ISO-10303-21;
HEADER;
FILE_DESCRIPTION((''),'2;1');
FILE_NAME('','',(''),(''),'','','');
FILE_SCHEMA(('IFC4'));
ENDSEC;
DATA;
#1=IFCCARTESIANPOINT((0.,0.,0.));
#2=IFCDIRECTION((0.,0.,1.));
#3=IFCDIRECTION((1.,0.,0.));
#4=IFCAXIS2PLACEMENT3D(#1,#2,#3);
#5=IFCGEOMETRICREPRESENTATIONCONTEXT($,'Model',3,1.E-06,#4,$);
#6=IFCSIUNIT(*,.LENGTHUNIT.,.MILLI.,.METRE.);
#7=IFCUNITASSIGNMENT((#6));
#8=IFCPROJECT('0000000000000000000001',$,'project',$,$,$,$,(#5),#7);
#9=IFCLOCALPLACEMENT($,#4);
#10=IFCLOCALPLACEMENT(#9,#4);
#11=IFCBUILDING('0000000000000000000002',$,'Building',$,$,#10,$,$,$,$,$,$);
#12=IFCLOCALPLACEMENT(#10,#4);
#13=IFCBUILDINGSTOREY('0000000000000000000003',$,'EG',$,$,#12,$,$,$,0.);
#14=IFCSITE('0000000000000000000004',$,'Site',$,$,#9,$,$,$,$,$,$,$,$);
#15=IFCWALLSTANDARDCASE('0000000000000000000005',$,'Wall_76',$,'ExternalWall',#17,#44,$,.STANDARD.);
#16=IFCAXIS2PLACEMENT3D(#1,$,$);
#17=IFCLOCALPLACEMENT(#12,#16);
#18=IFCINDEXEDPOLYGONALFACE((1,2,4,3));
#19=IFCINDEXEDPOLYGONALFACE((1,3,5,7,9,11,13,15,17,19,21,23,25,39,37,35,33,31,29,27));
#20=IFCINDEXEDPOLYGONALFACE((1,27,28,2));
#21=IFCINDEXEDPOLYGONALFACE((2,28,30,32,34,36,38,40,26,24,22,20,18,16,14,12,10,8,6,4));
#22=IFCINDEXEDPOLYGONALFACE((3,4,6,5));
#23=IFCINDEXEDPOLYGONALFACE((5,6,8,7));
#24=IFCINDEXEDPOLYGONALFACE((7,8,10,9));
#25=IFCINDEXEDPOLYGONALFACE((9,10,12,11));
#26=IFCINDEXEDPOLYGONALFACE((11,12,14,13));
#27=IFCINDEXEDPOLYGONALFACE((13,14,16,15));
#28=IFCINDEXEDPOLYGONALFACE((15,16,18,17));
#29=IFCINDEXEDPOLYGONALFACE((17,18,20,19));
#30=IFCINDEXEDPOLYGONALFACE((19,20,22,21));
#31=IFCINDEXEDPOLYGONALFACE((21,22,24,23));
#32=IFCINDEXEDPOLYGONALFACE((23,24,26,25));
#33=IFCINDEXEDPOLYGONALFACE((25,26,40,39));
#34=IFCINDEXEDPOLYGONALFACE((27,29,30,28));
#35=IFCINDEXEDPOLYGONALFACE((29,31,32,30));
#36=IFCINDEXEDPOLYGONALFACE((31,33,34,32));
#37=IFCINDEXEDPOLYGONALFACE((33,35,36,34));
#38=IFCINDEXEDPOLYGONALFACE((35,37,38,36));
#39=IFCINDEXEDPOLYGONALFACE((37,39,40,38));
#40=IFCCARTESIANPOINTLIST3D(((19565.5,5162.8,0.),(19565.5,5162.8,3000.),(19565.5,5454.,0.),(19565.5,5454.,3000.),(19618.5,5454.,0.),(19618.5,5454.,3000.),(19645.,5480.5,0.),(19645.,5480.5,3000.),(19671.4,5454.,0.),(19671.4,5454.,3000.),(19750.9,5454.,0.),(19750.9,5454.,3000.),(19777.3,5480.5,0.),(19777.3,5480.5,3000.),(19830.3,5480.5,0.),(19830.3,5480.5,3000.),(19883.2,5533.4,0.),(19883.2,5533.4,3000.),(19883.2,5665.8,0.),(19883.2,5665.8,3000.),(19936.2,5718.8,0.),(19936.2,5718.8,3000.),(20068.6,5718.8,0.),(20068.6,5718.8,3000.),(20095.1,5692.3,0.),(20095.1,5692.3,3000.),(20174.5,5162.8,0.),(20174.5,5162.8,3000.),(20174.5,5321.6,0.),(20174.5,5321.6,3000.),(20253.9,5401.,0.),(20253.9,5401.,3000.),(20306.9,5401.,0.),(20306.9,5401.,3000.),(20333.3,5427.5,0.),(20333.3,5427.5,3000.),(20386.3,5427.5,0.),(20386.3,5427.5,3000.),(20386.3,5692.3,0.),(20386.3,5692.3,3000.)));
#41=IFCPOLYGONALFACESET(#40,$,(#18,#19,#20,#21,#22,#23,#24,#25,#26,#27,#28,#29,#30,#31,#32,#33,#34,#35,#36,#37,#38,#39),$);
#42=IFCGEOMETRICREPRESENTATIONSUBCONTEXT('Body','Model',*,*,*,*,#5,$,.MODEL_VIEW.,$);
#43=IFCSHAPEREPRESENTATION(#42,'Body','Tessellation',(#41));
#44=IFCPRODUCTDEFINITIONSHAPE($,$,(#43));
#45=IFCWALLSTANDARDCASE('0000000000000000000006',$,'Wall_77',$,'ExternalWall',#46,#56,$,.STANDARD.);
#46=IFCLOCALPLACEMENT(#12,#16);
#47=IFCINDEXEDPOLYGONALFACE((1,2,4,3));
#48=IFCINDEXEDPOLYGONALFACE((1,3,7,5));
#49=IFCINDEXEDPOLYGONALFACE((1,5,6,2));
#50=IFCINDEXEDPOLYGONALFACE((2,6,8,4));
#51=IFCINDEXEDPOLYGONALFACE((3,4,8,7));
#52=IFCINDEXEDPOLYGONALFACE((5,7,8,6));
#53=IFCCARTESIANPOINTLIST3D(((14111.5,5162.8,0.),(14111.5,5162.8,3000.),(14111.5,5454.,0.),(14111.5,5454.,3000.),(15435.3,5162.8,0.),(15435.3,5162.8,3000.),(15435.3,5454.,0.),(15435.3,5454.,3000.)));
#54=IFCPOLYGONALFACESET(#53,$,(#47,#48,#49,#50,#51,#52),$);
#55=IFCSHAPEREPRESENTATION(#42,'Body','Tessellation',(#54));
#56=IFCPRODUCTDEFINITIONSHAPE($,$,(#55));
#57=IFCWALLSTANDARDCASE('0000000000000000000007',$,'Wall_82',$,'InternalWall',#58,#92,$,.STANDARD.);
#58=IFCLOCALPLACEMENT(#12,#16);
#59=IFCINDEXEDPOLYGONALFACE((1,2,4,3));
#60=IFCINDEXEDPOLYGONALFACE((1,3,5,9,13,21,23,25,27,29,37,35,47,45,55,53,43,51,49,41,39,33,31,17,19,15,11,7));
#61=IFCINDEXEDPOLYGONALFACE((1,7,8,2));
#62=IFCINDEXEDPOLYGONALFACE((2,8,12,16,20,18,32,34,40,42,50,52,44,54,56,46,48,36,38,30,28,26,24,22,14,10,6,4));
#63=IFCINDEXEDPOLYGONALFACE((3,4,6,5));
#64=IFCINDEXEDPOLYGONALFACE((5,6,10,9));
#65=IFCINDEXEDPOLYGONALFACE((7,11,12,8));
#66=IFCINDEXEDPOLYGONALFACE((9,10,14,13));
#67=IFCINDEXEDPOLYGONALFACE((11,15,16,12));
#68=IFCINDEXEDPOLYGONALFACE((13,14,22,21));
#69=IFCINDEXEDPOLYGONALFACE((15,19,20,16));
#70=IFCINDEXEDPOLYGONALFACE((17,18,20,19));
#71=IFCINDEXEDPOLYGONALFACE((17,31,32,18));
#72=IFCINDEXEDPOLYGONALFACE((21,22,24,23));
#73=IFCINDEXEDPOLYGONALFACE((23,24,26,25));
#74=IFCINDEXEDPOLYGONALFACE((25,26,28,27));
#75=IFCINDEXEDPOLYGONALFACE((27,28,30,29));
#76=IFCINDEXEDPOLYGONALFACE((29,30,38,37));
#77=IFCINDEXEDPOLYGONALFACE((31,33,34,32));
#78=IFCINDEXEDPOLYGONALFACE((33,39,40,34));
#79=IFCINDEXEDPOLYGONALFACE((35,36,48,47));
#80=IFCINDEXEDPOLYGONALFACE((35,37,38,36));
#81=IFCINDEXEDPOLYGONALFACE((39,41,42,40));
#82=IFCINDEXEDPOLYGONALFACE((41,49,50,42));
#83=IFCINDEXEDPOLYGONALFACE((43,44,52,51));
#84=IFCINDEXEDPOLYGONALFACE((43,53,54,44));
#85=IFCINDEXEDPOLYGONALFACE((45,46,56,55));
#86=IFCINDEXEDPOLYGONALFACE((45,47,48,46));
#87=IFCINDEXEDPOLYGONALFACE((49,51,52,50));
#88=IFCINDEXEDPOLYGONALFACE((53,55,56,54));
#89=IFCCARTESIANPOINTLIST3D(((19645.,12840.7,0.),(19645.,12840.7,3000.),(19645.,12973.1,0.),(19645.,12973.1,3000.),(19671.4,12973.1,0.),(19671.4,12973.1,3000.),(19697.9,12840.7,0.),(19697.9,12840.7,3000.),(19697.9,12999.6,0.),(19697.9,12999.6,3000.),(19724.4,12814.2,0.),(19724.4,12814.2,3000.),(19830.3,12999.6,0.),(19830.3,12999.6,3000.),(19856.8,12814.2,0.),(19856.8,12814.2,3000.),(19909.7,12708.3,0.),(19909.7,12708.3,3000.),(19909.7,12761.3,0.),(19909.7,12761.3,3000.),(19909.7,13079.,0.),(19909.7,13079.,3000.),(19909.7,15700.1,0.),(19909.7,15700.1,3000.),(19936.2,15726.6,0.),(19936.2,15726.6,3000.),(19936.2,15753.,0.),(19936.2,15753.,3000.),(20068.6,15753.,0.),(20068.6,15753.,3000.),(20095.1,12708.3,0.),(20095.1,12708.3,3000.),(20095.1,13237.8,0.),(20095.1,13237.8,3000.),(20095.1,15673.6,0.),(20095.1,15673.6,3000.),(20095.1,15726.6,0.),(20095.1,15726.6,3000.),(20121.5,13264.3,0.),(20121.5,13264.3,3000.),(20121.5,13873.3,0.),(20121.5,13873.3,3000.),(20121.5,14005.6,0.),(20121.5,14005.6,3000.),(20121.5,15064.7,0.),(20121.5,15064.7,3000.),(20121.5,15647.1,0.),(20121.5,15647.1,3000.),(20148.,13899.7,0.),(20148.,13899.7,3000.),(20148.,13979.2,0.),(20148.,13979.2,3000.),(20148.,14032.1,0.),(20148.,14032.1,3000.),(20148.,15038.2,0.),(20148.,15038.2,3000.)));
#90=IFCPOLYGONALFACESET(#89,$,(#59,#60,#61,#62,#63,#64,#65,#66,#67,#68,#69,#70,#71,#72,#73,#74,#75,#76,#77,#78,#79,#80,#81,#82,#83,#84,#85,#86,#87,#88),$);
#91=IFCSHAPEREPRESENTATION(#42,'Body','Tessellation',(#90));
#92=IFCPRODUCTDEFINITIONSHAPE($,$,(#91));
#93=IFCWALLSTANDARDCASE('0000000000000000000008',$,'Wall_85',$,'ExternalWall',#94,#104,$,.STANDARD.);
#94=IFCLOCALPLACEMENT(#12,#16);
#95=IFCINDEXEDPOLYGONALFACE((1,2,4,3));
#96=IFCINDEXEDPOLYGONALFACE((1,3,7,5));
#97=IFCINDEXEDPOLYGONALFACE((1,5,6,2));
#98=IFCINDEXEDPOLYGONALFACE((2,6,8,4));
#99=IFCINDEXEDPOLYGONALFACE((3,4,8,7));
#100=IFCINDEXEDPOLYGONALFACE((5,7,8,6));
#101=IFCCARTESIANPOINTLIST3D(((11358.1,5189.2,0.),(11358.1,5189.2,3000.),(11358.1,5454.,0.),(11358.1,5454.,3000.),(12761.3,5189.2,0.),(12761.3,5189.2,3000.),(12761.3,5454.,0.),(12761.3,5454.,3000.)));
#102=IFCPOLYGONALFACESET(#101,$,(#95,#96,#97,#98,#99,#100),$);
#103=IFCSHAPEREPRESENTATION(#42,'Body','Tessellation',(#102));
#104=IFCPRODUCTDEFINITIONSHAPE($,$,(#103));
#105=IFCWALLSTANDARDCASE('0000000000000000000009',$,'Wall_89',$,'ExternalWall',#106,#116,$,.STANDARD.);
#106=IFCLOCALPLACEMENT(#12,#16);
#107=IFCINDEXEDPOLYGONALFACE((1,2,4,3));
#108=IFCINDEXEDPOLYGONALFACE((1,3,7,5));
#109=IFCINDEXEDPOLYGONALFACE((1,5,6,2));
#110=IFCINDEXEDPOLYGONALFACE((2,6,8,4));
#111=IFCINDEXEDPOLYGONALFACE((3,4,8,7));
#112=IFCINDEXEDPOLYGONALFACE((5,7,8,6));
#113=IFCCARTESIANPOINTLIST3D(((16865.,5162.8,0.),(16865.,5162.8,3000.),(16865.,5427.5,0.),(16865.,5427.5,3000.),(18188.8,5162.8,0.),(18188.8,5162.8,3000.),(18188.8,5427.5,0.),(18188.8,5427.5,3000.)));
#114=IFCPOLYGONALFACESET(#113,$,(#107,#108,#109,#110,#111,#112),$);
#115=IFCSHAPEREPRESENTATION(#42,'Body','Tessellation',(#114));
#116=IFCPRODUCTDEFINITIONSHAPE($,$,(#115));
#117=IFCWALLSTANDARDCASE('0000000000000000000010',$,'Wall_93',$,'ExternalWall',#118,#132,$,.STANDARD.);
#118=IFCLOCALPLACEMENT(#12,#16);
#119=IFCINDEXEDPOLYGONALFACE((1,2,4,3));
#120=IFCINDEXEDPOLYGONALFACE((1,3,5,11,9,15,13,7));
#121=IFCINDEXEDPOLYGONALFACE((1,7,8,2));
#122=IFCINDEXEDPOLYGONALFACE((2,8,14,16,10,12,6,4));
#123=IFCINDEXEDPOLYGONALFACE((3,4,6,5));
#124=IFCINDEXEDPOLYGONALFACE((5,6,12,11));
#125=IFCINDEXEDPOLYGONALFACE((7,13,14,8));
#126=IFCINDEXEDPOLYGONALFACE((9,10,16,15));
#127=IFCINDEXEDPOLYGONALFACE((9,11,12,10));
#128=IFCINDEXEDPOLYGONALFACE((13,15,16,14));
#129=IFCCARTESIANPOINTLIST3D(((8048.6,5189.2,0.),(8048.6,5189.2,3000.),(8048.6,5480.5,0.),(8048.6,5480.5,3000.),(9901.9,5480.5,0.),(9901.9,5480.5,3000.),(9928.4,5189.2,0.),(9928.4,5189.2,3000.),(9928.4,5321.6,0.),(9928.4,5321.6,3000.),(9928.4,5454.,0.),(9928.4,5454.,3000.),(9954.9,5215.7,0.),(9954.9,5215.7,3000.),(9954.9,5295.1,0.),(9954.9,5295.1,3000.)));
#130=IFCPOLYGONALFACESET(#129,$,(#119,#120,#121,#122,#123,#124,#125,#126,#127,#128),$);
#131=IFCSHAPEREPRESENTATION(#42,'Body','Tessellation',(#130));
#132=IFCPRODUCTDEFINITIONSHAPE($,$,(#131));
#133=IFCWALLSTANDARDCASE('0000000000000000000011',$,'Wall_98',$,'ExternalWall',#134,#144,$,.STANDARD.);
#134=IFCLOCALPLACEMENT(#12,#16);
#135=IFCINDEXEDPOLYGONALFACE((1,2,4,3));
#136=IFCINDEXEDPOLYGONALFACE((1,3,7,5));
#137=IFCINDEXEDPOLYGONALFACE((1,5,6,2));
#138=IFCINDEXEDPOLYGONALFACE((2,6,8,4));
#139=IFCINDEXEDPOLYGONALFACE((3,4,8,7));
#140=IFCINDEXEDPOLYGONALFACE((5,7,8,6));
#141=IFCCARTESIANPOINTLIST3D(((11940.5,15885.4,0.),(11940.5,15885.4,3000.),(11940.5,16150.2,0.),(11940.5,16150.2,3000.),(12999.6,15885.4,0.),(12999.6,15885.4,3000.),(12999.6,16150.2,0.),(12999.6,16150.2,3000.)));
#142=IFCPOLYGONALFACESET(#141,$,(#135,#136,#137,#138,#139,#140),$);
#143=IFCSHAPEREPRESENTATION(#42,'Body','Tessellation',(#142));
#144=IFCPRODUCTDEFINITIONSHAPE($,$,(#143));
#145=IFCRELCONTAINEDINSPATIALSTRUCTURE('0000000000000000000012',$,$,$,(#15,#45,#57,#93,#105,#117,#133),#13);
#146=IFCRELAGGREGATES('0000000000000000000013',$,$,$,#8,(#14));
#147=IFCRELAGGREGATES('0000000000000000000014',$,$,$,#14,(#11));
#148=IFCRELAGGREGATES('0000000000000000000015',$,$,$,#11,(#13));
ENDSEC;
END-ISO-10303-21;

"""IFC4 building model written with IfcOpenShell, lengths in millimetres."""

from ifc_helpers import new_model, si_unit, frame, origin_with_axes, place, context, subcontext, project, spatial, polyline, outline, extrude, element, save


model = new_model("IFC4")

# Units and contexts
model_context = context("Model", 3, precision=1e-06, world=origin_with_axes())
body_context = subcontext(model_context, "Body", "Model", "MODEL_VIEW")
ifc_project = project(units=[si_unit("LENGTHUNIT", "METRE", prefix="MILLI")], contexts=[model_context])

# Site, building, storey
site_placement = place(None, origin_with_axes())
site = spatial("IfcSite", under=ifc_project, at=site_placement, Name="Site")
building_placement = place(site_placement, origin_with_axes())
building = spatial("IfcBuilding", under=site, at=building_placement, Name="Building")
storey_placement = place(building_placement, origin_with_axes())
storey = spatial("IfcBuildingStorey", under=building, at=storey_placement, Name="EG", Elevation=0.0)

# Walls
wall_placement = place(storey_placement, origin_with_axes())
element("IfcWallStandardCase", 1, at=wall_placement, inside=storey, Name="Wall_76", ObjectType="ExternalWall", PredefinedType="STANDARD", context=body_context, shape_type="SweptSolid", body=[
    extrude(outline(polyline([(19565.5, 5162.8, 0.0), (19565.5, 5454.0, 0.0), (19618.5, 5454.0, 0.0), (19645.0, 5480.5, 0.0), (19671.4, 5454.0, 0.0), (19750.9, 5454.0, 0.0), (19777.3, 5480.5, 0.0), (19830.3, 5480.5, 0.0), (19883.2, 5533.4, 0.0), (19883.2, 5665.8, 0.0), (19936.2, 5718.8, 0.0), (20068.6, 5718.8, 0.0), (20095.1, 5692.3, 0.0), (20386.3, 5692.3, 0.0), (20386.3, 5427.5, 0.0), (20333.3, 5427.5, 0.0), (20306.9, 5401.0, 0.0), (20253.9, 5401.0, 0.0), (20174.5, 5321.6, 0.0), (20174.5, 5162.8, 0.0), (19565.5, 5162.8, 0.0)])), origin_with_axes(), (0.0, 0.0, 1.0), 3000.0),
])
for number, where, z_axis, x_axis, name in (
    (2, (0.0, 0.0, 0.0), (0.0, 0.0, 1.0), (1.0, 0.0, 0.0), "Wall_77"),
):
    element("IfcWallStandardCase", number, at=place(storey_placement, frame(where, z_axis=z_axis, x_axis=x_axis)), inside=storey, Name=name, ObjectType="ExternalWall", PredefinedType="STANDARD", context=body_context, shape_type="SweptSolid", body=[
        extrude(outline(polyline([(14111.5, 5162.8, 0.0), (14111.5, 5454.0, 0.0), (15435.3, 5454.0, 0.0), (15435.3, 5162.8, 0.0), (14111.5, 5162.8, 0.0)])), origin_with_axes(), (0.0, 0.0, 1.0), 3000.0),
    ])
for number, where, z_axis, x_axis, name in (
    (3, (0.0, 0.0, 0.0), (0.0, 0.0, 1.0), (1.0, 0.0, 0.0), "Wall_82"),
):
    element("IfcWallStandardCase", number, at=place(storey_placement, frame(where, z_axis=z_axis, x_axis=x_axis)), inside=storey, Name=name, ObjectType="InternalWall", PredefinedType="STANDARD", context=body_context, shape_type="SweptSolid", body=[
        extrude(outline(polyline([(19909.7, 12708.3, 0.0), (19909.7, 12761.3, 0.0), (19856.8, 12814.2, 0.0), (19724.4, 12814.2, 0.0), (19697.9, 12840.7, 0.0), (19645.0, 12840.7, 0.0), (19645.0, 12973.1, 0.0), (19671.4, 12973.1, 0.0), (19697.9, 12999.6, 0.0), (19830.3, 12999.6, 0.0), (19909.7, 13079.0, 0.0), (19909.7, 15700.1, 0.0), (19936.2, 15726.6, 0.0), (19936.2, 15753.0, 0.0), (20068.6, 15753.0, 0.0), (20095.1, 15726.6, 0.0), (20095.1, 15673.6, 0.0), (20121.5, 15647.1, 0.0), (20121.5, 15064.7, 0.0), (20148.0, 15038.2, 0.0), (20148.0, 14032.1, 0.0), (20121.5, 14005.6, 0.0), (20148.0, 13979.2, 0.0), (20148.0, 13899.7, 0.0), (20121.5, 13873.3, 0.0), (20121.5, 13264.3, 0.0), (20095.1, 13237.8, 0.0), (20095.1, 12708.3, 0.0), (19909.7, 12708.3, 0.0)])), origin_with_axes(), (0.0, 0.0, 1.0), 3000.0),
    ])
for number, where, z_axis, x_axis, name in (
    (4, (0.0, 0.0, 0.0), (0.0, 0.0, 1.0), (1.0, 0.0, 0.0), "Wall_85"),
):
    element("IfcWallStandardCase", number, at=place(storey_placement, frame(where, z_axis=z_axis, x_axis=x_axis)), inside=storey, Name=name, ObjectType="ExternalWall", PredefinedType="STANDARD", context=body_context, shape_type="SweptSolid", body=[
        extrude(outline(polyline([(11358.1, 5189.2, 0.0), (11358.1, 5454.0, 0.0), (12761.3, 5454.0, 0.0), (12761.3, 5189.2, 0.0), (11358.1, 5189.2, 0.0)])), origin_with_axes(), (0.0, 0.0, 1.0), 3000.0),
    ])
for number, where, z_axis, x_axis, name in (
    (5, (0.0, 0.0, 0.0), (0.0, 0.0, 1.0), (1.0, 0.0, 0.0), "Wall_89"),
):
    element("IfcWallStandardCase", number, at=place(storey_placement, frame(where, z_axis=z_axis, x_axis=x_axis)), inside=storey, Name=name, ObjectType="ExternalWall", PredefinedType="STANDARD", context=body_context, shape_type="SweptSolid", body=[
        extrude(outline(polyline([(16865.0, 5162.8, 0.0), (16865.0, 5427.5, 0.0), (18188.8, 5427.5, 0.0), (18188.8, 5162.8, 0.0), (16865.0, 5162.8, 0.0)])), origin_with_axes(), (0.0, 0.0, 1.0), 3000.0),
    ])
for number, where, z_axis, x_axis, name in (
    (6, (0.0, 0.0, 0.0), (0.0, 0.0, 1.0), (1.0, 0.0, 0.0), "Wall_93"),
):
    element("IfcWallStandardCase", number, at=place(storey_placement, frame(where, z_axis=z_axis, x_axis=x_axis)), inside=storey, Name=name, ObjectType="ExternalWall", PredefinedType="STANDARD", context=body_context, shape_type="SweptSolid", body=[
        extrude(outline(polyline([(8048.6, 5189.2, 0.0), (8048.6, 5480.5, 0.0), (9901.9, 5480.5, 0.0), (9928.4, 5454.0, 0.0), (9928.4, 5321.6, 0.0), (9954.9, 5295.1, 0.0), (9954.9, 5215.7, 0.0), (9928.4, 5189.2, 0.0), (8048.6, 5189.2, 0.0)])), origin_with_axes(), (0.0, 0.0, 1.0), 3000.0),
    ])
for number, where, z_axis, x_axis, name in (
    (7, (0.0, 0.0, 0.0), (0.0, 0.0, 1.0), (1.0, 0.0, 0.0), "Wall_98"),
):
    element("IfcWallStandardCase", number, at=place(storey_placement, frame(where, z_axis=z_axis, x_axis=x_axis)), inside=storey, Name=name, ObjectType="ExternalWall", PredefinedType="STANDARD", context=body_context, shape_type="SweptSolid", body=[
        extrude(outline(polyline([(11940.5, 15885.4, 0.0), (11940.5, 16150.2, 0.0), (12999.6, 16150.2, 0.0), (12999.6, 15885.4, 0.0), (11940.5, 15885.4, 0.0)])), origin_with_axes(), (0.0, 0.0, 1.0), 3000.0),
    ])

save(model, "model.ifc")
